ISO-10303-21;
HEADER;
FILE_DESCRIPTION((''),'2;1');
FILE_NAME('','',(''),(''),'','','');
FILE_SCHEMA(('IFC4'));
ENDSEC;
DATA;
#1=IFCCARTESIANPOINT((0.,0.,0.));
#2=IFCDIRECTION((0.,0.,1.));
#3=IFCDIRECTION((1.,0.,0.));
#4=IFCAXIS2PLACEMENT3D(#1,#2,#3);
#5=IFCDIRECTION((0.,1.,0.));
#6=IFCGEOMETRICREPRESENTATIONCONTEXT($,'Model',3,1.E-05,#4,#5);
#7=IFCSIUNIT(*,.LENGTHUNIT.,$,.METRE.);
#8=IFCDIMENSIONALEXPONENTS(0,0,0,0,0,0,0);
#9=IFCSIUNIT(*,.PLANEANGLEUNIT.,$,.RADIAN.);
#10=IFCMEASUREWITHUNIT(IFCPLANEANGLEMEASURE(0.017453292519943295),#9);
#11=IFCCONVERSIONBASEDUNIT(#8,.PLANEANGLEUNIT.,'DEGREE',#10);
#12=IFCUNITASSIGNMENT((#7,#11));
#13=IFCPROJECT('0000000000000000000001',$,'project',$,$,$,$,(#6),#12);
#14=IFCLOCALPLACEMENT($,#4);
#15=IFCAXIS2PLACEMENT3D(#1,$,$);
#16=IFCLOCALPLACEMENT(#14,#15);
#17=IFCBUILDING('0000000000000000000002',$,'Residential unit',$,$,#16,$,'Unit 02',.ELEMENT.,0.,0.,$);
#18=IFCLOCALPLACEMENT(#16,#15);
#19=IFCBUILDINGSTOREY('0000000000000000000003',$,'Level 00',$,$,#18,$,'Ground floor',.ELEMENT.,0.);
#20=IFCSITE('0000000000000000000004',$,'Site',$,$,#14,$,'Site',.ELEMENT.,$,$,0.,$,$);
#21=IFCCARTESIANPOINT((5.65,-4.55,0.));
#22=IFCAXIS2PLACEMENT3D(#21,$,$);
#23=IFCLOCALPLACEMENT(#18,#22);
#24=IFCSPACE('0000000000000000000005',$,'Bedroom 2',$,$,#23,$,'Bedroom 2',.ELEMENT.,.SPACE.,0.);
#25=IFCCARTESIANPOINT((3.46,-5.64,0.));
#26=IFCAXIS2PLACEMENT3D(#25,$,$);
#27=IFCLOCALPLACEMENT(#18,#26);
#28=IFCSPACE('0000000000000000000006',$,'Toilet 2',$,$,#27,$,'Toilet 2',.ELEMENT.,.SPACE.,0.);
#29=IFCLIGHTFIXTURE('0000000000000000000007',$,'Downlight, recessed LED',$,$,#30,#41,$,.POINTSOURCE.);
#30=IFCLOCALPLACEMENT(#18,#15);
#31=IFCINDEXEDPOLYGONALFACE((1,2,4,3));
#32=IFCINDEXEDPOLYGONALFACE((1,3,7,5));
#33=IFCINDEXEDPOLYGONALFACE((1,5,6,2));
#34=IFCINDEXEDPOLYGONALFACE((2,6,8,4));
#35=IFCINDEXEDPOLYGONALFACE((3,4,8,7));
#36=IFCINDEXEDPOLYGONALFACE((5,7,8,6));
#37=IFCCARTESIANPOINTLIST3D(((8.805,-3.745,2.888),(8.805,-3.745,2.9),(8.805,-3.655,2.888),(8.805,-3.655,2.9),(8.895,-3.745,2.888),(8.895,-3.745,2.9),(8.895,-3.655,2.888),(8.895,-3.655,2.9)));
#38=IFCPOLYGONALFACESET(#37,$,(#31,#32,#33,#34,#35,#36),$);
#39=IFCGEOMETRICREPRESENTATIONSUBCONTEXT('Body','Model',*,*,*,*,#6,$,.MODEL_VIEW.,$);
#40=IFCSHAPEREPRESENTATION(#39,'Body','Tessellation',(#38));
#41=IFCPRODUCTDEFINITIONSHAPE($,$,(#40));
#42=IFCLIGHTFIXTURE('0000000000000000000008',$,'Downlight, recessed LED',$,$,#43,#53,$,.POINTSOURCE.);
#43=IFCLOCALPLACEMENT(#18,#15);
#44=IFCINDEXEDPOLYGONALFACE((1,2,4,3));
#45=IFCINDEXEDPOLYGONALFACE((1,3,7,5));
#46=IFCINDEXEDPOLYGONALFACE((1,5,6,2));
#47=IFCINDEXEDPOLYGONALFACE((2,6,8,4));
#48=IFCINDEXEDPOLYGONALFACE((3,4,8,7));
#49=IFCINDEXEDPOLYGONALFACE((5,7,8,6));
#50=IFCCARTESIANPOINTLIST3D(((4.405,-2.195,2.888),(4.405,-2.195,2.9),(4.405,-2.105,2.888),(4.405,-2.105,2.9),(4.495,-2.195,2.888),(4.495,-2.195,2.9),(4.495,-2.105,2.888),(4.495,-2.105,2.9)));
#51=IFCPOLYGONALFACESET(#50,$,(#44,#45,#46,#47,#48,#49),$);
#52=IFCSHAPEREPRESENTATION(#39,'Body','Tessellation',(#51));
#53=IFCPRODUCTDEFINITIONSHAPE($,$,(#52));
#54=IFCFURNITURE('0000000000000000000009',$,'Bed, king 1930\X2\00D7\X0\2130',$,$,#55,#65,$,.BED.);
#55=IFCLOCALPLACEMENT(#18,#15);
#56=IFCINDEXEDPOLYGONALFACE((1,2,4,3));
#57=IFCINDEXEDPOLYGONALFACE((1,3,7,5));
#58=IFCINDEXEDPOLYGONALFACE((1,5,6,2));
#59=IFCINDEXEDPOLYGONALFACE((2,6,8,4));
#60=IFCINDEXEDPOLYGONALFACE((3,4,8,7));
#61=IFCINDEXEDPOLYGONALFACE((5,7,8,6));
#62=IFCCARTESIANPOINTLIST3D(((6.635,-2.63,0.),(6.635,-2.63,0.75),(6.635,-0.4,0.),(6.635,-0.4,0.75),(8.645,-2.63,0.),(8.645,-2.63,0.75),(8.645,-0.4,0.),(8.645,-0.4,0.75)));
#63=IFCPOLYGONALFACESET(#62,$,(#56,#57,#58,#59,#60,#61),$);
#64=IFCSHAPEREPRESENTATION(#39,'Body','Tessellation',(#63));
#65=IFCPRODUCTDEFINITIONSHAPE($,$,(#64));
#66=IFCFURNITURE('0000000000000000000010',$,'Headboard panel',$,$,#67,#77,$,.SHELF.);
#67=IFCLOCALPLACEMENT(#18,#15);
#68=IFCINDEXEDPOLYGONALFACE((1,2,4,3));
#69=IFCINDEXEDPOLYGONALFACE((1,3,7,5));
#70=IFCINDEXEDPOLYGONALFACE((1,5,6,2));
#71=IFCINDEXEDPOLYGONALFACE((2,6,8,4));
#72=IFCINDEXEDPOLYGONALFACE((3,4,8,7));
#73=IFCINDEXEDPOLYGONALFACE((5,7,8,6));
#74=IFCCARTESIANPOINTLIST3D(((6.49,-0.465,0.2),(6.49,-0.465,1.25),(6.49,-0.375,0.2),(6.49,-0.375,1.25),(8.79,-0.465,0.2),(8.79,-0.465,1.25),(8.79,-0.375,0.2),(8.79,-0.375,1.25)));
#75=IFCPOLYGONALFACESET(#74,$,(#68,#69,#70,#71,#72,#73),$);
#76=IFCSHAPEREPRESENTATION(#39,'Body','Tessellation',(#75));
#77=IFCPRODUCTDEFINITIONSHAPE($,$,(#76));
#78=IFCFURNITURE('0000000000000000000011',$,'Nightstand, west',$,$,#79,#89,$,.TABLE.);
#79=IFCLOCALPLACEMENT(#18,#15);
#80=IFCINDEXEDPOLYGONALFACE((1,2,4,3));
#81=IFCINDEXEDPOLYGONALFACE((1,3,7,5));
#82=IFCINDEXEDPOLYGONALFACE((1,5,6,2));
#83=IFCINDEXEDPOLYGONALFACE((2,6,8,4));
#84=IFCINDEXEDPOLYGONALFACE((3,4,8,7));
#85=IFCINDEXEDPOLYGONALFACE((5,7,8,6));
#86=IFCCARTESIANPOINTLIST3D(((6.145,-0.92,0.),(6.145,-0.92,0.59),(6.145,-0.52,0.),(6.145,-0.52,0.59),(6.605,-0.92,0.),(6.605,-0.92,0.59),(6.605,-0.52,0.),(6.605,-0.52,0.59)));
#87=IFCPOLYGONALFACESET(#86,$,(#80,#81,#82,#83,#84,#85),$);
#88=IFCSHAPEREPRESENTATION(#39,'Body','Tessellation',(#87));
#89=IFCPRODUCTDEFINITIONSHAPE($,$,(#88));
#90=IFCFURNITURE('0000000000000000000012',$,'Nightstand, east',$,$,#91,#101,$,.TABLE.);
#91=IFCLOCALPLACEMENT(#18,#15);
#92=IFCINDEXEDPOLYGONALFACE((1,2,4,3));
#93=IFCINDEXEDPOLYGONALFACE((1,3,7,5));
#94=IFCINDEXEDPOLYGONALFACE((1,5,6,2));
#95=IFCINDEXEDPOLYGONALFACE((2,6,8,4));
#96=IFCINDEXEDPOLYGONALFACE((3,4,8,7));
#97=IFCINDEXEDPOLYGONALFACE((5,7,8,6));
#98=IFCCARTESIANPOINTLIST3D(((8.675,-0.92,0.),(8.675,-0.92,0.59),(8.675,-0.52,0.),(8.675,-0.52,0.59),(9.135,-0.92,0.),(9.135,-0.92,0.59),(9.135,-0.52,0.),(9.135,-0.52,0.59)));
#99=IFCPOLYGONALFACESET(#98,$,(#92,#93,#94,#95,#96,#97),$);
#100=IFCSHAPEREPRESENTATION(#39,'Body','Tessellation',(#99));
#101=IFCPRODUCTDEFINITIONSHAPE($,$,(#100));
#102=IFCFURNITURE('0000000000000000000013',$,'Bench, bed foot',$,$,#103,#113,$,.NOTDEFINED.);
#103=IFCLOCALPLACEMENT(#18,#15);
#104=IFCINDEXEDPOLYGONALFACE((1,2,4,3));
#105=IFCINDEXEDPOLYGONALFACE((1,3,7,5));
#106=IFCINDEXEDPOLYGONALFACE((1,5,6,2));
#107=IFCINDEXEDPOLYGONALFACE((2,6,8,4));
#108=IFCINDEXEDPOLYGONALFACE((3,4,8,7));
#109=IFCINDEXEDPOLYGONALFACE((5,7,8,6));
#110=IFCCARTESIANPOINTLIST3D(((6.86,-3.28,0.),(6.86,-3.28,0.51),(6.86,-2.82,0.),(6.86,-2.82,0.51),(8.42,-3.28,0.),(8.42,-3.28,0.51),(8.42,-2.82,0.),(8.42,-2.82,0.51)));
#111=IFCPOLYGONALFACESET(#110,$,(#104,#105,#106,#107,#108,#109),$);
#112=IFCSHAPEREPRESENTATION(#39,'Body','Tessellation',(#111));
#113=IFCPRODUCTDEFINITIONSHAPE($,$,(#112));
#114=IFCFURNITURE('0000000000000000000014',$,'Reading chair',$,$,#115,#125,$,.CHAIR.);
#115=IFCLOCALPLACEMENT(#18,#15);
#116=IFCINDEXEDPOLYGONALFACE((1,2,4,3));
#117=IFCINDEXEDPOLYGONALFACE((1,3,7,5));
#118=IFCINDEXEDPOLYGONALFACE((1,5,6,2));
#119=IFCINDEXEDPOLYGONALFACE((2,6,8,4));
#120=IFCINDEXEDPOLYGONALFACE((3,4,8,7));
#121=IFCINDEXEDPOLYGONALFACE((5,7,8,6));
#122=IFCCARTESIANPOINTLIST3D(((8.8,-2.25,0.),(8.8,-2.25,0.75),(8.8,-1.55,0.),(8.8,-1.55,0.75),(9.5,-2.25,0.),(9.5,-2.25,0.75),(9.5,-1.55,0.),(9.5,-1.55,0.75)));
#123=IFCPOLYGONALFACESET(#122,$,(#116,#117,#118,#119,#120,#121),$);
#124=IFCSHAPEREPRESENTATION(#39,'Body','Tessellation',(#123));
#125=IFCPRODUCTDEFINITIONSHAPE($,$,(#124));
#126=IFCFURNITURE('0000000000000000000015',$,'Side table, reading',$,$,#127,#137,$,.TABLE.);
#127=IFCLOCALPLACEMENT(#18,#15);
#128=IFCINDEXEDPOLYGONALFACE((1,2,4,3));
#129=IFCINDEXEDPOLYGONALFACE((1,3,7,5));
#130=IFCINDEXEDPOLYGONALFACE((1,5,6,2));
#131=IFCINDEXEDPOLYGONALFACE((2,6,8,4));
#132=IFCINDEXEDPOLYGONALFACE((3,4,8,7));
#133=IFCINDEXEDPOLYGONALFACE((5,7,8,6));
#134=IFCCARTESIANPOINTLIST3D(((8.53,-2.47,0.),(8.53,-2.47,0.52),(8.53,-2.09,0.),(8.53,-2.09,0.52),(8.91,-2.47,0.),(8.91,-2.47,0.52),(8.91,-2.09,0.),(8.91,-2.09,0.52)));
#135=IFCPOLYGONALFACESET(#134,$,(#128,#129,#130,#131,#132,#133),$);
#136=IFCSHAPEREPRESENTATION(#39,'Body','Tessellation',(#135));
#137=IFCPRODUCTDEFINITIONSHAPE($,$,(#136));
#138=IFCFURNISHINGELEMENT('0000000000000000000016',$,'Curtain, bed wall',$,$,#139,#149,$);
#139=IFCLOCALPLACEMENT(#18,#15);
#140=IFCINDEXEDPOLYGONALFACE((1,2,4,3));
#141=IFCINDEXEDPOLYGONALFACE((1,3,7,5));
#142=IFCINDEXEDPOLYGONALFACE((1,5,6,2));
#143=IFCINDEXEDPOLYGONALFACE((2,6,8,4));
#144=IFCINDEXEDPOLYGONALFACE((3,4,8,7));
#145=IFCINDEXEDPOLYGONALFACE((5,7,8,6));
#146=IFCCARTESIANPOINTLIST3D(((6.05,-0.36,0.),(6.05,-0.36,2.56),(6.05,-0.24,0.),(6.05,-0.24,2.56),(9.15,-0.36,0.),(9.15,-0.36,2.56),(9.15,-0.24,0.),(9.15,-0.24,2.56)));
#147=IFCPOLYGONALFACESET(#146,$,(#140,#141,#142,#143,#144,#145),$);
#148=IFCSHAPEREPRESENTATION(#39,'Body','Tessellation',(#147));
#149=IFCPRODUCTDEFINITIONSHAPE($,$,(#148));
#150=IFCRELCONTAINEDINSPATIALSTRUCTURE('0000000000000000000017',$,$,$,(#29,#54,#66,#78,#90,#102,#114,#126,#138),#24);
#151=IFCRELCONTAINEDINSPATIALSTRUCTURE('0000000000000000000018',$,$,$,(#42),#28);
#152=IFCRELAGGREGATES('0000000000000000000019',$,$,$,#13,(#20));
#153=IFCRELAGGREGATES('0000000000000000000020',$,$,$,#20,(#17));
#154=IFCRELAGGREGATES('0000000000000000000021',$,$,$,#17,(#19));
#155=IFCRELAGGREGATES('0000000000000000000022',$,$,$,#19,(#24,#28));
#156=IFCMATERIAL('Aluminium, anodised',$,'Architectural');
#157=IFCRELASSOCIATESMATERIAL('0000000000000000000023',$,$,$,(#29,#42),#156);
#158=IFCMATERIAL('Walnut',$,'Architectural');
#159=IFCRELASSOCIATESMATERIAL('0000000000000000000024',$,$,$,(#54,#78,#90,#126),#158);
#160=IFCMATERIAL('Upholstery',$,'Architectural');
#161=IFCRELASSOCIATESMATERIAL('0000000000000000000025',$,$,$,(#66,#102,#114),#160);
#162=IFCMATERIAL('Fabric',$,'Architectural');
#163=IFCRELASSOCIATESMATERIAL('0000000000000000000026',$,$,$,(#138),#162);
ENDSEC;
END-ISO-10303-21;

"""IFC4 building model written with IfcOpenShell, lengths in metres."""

from ifc_helpers import new_model, entity, si_unit, converted_unit, direction, frame, frame_2d, origin, origin_with_axes, place, context, subcontext, project, spatial, rectangle, extrude, material, element, save


model = new_model("IFC4")

# Units and contexts
model_context = context("Model", 3, precision=1e-05, world=origin_with_axes(), true_north=direction((0.0, 1.0, 0.0)))
body_context = subcontext(model_context, "Body", "Model", "MODEL_VIEW")
ifc_project = project(units=[si_unit("LENGTHUNIT", "METRE"), converted_unit("PLANEANGLEUNIT", "DEGREE", entity("IfcPlaneAngleMeasure", 0.017453292519943295), si_unit("PLANEANGLEUNIT", "RADIAN"), dimensions=[0, 0, 0, 0, 0, 0, 0])], contexts=[model_context])

# Site, building, storey
site_placement = place(None, origin_with_axes())
site = spatial("IfcSite", under=ifc_project, at=site_placement, Name="Site", LongName="Site", CompositionType="ELEMENT", RefElevation=0.0)
building_placement = place(site_placement, origin())
building = spatial("IfcBuilding", under=site, at=building_placement, Name="Residential unit", LongName="Unit 02", CompositionType="ELEMENT", ElevationOfRefHeight=0.0, ElevationOfTerrain=0.0)
storey_placement = place(building_placement, origin())
storey = spatial("IfcBuildingStorey", under=building, at=storey_placement, Name="Level 00", LongName="Ground floor", CompositionType="ELEMENT", Elevation=0.0)

# Shared definitions
space_1_placement = place(storey_placement, frame((5.65, -4.55, 0.0)))
space_1 = spatial("IfcSpace", under=storey, at=space_1_placement, Name="Bedroom 2", LongName="Bedroom 2", CompositionType="ELEMENT", PredefinedType="SPACE", ElevationWithFlooring=0.0)

# Shared definitions
space_2_placement = place(storey_placement, frame((3.46, -5.64, 0.0)))
space_2 = spatial("IfcSpace", under=storey, at=space_2_placement, Name="Toilet 2", LongName="Toilet 2", CompositionType="ELEMENT", PredefinedType="SPACE", ElevationWithFlooring=0.0)

# Light fixtures
ifc_material_1 = material(Name="Aluminium, anodised", Category="Architectural")
for number, where, name in (
    (1, (8.805, -3.745, 2.888), "Downlight, recessed LED"),
):
    element("IfcLightFixture", number, at=place(storey_placement, frame(where)), inside=space_1, material=ifc_material_1, Name=name, PredefinedType="POINTSOURCE", context=body_context, shape_type="SweptSolid", body=[
        extrude(rectangle(XDim=0.09, YDim=0.09, at=frame_2d((0.045, 0.045))), origin(), (0.0, 0.0, 1.0), 0.012),
    ])
light_fixture_placement = place(storey_placement, frame((4.405, -2.195, 2.888)))
element("IfcLightFixture", 2, at=light_fixture_placement, inside=space_2, material=ifc_material_1, Name="Downlight, recessed LED", PredefinedType="POINTSOURCE", context=body_context, shape_type="SweptSolid", body=[
    extrude(rectangle(XDim=0.09, YDim=0.09, at=frame_2d((0.045, 0.045))), origin(), (0.0, 0.0, 1.0), 0.012),
])

# Furniture
ifc_material_2 = material(Name="Walnut", Category="Architectural")
furniture_1_placement = place(storey_placement, frame((6.635, -2.63, 0.0)))
element("IfcFurniture", 3, at=furniture_1_placement, inside=space_1, material=ifc_material_2, Name="Bed, king 1930×2130", PredefinedType="BED", context=body_context, shape_type="SweptSolid", body=[
    extrude(rectangle(XDim=2.01, YDim=2.23, at=frame_2d((1.005, 1.115))), origin(), (0.0, 0.0, 1.0), 0.75),
])
ifc_material_3 = material(Name="Upholstery", Category="Architectural")
furniture_2_placement = place(storey_placement, frame((6.49, -0.465, 0.2)))
element("IfcFurniture", 4, at=furniture_2_placement, inside=space_1, material=ifc_material_3, Name="Headboard panel", PredefinedType="SHELF", context=body_context, shape_type="SweptSolid", body=[
    extrude(rectangle(XDim=2.3, YDim=0.09, at=frame_2d((1.15, 0.045))), origin(), (0.0, 0.0, 1.0), 1.05),
])
for number, where, name in (
    (5, (6.145, -0.92, 0.0), "Nightstand, west"),
    (6, (8.675, -0.92, 0.0), "Nightstand, east"),
):
    element("IfcFurniture", number, at=place(storey_placement, frame(where)), inside=space_1, material=ifc_material_2, Name=name, PredefinedType="TABLE", context=body_context, shape_type="SweptSolid", body=[
        extrude(rectangle(XDim=0.46, YDim=0.4, at=frame_2d((0.23, 0.2))), origin(), (0.0, 0.0, 1.0), 0.59),
    ])
furniture_3_placement = place(storey_placement, frame((6.86, -3.28, 0.0)))
element("IfcFurniture", 7, at=furniture_3_placement, inside=space_1, material=ifc_material_3, Name="Bench, bed foot", PredefinedType="NOTDEFINED", context=body_context, shape_type="SweptSolid", body=[
    extrude(rectangle(XDim=1.56, YDim=0.46, at=frame_2d((0.78, 0.23))), origin(), (0.0, 0.0, 1.0), 0.51),
])
furniture_4_placement = place(storey_placement, frame((8.8, -2.25, 0.0)))
element("IfcFurniture", 8, at=furniture_4_placement, inside=space_1, material=ifc_material_3, Name="Reading chair", PredefinedType="CHAIR", context=body_context, shape_type="SweptSolid", body=[
    extrude(rectangle(XDim=0.7, YDim=0.7, at=frame_2d((0.35, 0.35))), origin(), (0.0, 0.0, 1.0), 0.75),
])
furniture_5_placement = place(storey_placement, frame((8.53, -2.47, 0.0)))
element("IfcFurniture", 9, at=furniture_5_placement, inside=space_1, material=ifc_material_2, Name="Side table, reading", PredefinedType="TABLE", context=body_context, shape_type="SweptSolid", body=[
    extrude(rectangle(XDim=0.38, YDim=0.38, at=frame_2d((0.19, 0.19))), origin(), (0.0, 0.0, 1.0), 0.52),
])

# Furnishing element
ifc_material_4 = material(Name="Fabric", Category="Architectural")
furnishing_placement = place(storey_placement, frame((6.05, -0.36, 0.0)))
element("IfcFurnishingElement", 10, at=furnishing_placement, inside=space_1, material=ifc_material_4, Name="Curtain, bed wall", context=body_context, shape_type="SweptSolid", body=[
    extrude(rectangle(XDim=3.1, YDim=0.12, at=frame_2d((1.55, 0.06))), origin(), (0.0, 0.0, 1.0), 2.56),
])

save(model, "model.ifc")
